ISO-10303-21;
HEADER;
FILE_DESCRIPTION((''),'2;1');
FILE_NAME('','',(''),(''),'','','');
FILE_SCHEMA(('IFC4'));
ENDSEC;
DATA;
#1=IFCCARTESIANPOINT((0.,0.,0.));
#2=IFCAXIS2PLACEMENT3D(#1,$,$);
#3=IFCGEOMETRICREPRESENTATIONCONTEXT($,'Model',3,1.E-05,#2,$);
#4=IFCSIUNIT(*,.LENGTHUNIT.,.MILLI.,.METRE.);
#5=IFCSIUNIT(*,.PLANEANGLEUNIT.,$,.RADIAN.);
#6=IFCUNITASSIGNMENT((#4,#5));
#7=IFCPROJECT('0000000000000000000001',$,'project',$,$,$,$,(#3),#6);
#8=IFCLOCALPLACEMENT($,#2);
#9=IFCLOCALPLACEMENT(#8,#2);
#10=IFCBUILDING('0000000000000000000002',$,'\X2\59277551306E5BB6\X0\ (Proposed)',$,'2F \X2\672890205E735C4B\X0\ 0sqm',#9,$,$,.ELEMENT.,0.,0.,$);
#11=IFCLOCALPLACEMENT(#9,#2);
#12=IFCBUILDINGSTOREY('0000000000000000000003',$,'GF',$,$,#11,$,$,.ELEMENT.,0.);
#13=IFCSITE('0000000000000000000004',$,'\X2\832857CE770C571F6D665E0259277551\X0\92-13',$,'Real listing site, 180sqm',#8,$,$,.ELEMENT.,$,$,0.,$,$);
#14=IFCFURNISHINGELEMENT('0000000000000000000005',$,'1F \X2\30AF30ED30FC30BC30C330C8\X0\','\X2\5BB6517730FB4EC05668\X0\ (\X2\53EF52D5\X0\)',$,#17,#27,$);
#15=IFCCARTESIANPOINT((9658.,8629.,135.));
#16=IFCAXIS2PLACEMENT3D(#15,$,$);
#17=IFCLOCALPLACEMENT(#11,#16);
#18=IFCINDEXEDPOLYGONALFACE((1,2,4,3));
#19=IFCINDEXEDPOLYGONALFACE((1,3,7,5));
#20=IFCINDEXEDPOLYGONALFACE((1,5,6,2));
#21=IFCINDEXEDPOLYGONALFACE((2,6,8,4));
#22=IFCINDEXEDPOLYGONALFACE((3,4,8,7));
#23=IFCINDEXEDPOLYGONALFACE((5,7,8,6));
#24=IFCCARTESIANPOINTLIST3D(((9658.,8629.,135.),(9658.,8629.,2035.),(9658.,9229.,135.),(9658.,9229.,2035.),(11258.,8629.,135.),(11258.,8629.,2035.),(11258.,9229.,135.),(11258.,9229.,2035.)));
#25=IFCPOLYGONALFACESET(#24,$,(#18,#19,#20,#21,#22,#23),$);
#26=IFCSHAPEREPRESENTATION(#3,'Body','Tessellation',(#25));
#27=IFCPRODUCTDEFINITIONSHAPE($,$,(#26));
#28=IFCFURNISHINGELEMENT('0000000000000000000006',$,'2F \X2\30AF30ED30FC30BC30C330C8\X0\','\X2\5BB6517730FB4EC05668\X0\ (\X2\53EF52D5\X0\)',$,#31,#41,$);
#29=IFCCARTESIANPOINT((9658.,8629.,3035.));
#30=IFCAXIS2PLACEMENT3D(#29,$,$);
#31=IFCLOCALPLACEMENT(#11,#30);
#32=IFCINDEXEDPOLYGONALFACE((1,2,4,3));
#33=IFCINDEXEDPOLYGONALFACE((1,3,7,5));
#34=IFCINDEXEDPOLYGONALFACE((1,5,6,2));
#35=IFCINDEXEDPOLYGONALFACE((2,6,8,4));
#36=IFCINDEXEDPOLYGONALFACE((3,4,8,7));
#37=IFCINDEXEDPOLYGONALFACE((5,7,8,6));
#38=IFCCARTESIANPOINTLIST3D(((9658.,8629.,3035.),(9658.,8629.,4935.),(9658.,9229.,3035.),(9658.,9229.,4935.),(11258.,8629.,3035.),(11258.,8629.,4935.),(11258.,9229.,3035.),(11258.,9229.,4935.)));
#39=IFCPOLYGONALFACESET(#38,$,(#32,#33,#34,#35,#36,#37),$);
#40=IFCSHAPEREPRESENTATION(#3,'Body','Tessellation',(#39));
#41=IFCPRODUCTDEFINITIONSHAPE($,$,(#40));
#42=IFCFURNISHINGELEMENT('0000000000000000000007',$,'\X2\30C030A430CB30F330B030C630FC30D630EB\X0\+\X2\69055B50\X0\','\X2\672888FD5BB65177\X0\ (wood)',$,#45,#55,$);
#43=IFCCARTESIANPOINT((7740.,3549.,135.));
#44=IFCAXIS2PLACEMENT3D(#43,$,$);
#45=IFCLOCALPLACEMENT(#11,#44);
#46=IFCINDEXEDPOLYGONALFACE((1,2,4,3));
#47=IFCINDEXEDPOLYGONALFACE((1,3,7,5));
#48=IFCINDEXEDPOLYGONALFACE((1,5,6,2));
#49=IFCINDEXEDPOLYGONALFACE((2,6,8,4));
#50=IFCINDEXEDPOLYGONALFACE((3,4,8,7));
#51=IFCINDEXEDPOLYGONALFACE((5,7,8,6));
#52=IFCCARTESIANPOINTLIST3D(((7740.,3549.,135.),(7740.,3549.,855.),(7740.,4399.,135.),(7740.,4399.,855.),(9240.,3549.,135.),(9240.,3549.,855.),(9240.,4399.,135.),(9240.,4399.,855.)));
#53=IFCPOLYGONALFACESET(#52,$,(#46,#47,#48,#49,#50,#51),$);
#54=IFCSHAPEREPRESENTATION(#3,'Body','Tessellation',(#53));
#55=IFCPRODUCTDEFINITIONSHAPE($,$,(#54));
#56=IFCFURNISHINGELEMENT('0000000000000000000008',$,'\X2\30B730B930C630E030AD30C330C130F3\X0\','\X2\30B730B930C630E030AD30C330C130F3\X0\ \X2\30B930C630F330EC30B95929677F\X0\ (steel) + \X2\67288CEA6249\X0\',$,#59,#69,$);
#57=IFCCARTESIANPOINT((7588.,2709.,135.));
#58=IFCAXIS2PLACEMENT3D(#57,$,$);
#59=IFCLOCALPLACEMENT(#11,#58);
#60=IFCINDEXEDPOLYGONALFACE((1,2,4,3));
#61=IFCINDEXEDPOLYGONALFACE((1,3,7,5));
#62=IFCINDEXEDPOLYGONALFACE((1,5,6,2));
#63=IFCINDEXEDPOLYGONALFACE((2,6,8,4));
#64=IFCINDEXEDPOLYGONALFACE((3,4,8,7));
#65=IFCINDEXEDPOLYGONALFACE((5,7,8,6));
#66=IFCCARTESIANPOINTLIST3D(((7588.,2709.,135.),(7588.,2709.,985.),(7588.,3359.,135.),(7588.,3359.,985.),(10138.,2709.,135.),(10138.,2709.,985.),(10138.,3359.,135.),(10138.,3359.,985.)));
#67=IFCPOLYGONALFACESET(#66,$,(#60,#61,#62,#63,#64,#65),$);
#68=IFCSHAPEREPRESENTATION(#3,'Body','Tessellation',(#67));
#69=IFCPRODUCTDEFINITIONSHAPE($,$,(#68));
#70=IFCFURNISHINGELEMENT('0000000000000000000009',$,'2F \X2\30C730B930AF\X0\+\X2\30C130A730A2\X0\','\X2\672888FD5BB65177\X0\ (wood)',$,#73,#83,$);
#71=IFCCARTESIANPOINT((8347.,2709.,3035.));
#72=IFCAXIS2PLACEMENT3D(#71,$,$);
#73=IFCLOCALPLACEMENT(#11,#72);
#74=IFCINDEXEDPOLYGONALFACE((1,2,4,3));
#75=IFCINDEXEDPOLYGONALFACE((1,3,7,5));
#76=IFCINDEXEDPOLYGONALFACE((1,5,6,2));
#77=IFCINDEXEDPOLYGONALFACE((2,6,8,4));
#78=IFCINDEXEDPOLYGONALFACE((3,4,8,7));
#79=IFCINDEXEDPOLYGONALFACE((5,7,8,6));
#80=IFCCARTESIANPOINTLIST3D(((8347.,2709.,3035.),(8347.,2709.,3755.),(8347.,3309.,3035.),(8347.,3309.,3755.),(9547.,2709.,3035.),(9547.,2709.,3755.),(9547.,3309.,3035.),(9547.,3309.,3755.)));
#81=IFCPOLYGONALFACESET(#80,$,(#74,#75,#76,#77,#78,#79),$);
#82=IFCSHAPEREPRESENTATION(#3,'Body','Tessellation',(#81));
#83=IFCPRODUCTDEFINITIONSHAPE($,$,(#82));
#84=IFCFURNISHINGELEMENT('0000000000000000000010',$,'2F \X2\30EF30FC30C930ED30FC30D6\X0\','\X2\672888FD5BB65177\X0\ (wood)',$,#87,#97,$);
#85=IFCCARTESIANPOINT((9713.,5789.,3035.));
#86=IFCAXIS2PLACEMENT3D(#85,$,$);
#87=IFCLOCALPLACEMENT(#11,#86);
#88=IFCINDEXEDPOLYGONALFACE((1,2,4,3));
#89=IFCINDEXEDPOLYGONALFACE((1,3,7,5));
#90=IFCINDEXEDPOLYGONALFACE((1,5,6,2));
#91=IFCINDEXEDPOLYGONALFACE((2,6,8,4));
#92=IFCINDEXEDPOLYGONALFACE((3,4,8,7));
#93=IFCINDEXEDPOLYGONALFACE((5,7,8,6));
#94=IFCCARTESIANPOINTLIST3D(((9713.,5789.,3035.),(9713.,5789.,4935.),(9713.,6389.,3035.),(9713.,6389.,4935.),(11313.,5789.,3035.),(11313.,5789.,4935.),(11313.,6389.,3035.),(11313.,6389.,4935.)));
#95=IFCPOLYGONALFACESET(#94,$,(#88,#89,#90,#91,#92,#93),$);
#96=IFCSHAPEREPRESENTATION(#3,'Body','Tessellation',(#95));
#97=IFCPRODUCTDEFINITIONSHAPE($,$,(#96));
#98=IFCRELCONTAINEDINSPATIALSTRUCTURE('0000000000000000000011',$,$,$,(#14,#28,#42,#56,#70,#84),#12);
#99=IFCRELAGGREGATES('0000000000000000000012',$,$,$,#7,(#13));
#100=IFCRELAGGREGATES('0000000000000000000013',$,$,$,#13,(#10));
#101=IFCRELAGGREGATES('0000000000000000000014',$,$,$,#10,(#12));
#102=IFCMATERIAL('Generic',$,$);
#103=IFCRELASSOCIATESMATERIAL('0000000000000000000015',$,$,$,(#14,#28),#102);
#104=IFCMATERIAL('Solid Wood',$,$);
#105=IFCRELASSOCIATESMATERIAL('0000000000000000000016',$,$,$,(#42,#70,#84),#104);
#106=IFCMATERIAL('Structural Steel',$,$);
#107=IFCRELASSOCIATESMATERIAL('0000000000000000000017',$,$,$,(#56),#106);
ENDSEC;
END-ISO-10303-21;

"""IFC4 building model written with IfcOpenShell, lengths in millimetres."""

from ifc_helpers import new_model, si_unit, frame, frame_2d, origin, place, context, project, spatial, rectangle, extrude, material, element, save


model = new_model("IFC4")

# Units and contexts
model_context = context("Model", 3, precision=1e-05, world=origin())
ifc_project = project(units=[si_unit("LENGTHUNIT", "METRE", prefix="MILLI"), si_unit("PLANEANGLEUNIT", "RADIAN")], contexts=[model_context])

# Site, building, storey
site_placement = place(None, origin())
site = spatial("IfcSite", under=ifc_project, at=site_placement, Name="茨城県土浦市大畑92-13", ObjectType="Real listing site, 180sqm", CompositionType="ELEMENT", RefElevation=0.0)
building_placement = place(site_placement, origin())
building = spatial("IfcBuilding", under=site, at=building_placement, Name="大畑の家 (Proposed)", ObjectType="2F 木造平屋 0sqm", CompositionType="ELEMENT", ElevationOfRefHeight=0.0, ElevationOfTerrain=0.0)
storey_placement = place(building_placement, origin())
storey = spatial("IfcBuildingStorey", under=building, at=storey_placement, Name="GF", CompositionType="ELEMENT", Elevation=0.0)

# Shared definitions
ifc_material_1 = material(Name="Solid Wood")

# Shared definitions
ifc_material_2 = material(Name="Generic")

# Furnishing elements
furnishing_1_placement = place(storey_placement, frame((9658.0, 8629.0, 135.0)))
element("IfcFurnishingElement", 1, at=furnishing_1_placement, inside=storey, material=ifc_material_2, Name="1F クローゼット", Description="家具・什器 (可動)", context=model_context, shape_type="SweptSolid", body=[
    extrude(rectangle(XDim=1600.0, YDim=600.0, at=frame_2d((800.0, 300.0))), frame((9658.0, 8629.0, 135.0)), (0.0, 0.0, 1.0), 1900.0),
])
furnishing_2_placement = place(storey_placement, frame((9658.0, 8629.0, 3035.0)))
element("IfcFurnishingElement", 2, at=furnishing_2_placement, inside=storey, material=ifc_material_2, Name="2F クローゼット", Description="家具・什器 (可動)", context=model_context, shape_type="SweptSolid", body=[
    extrude(rectangle(XDim=1600.0, YDim=600.0, at=frame_2d((800.0, 300.0))), frame((9658.0, 8629.0, 3035.0)), (0.0, 0.0, 1.0), 1900.0),
])
furnishing_3_placement = place(storey_placement, frame((7740.0, 3549.0, 135.0)))
element("IfcFurnishingElement", 3, at=furnishing_3_placement, inside=storey, material=ifc_material_1, Name="ダイニングテーブル+椅子", Description="木製家具 (wood)", context=model_context, shape_type="SweptSolid", body=[
    extrude(rectangle(XDim=1500.0, YDim=850.0, at=frame_2d((750.0, 425.0))), frame((7740.0, 3549.0, 135.0)), (0.0, 0.0, 1.0), 720.0),
])
ifc_material_3 = material(Name="Structural Steel")
furnishing_4_placement = place(storey_placement, frame((7588.0, 2709.0, 135.0)))
element("IfcFurnishingElement", 4, at=furnishing_4_placement, inside=storey, material=ifc_material_3, Name="システムキッチン", Description="システムキッチン ステンレス天板 (steel) + 木質扉", context=model_context, shape_type="SweptSolid", body=[
    extrude(rectangle(XDim=2550.0, YDim=650.0, at=frame_2d((1275.0, 325.0))), frame((7588.0, 2709.0, 135.0)), (0.0, 0.0, 1.0), 850.0),
])
furnishing_5_placement = place(storey_placement, frame((8347.0, 2709.0, 3035.0)))
element("IfcFurnishingElement", 5, at=furnishing_5_placement, inside=storey, material=ifc_material_1, Name="2F デスク+チェア", Description="木製家具 (wood)", context=model_context, shape_type="SweptSolid", body=[
    extrude(rectangle(XDim=1200.0, YDim=600.0, at=frame_2d((600.0, 300.0))), frame((8347.0, 2709.0, 3035.0)), (0.0, 0.0, 1.0), 720.0),
])
furnishing_6_placement = place(storey_placement, frame((9713.0, 5789.0, 3035.0)))
element("IfcFurnishingElement", 6, at=furnishing_6_placement, inside=storey, material=ifc_material_1, Name="2F ワードローブ", Description="木製家具 (wood)", context=model_context, shape_type="SweptSolid", body=[
    extrude(rectangle(XDim=1600.0, YDim=600.0, at=frame_2d((800.0, 300.0))), frame((9713.0, 5789.0, 3035.0)), (0.0, 0.0, 1.0), 1900.0),
])

save(model, "model.ifc")
